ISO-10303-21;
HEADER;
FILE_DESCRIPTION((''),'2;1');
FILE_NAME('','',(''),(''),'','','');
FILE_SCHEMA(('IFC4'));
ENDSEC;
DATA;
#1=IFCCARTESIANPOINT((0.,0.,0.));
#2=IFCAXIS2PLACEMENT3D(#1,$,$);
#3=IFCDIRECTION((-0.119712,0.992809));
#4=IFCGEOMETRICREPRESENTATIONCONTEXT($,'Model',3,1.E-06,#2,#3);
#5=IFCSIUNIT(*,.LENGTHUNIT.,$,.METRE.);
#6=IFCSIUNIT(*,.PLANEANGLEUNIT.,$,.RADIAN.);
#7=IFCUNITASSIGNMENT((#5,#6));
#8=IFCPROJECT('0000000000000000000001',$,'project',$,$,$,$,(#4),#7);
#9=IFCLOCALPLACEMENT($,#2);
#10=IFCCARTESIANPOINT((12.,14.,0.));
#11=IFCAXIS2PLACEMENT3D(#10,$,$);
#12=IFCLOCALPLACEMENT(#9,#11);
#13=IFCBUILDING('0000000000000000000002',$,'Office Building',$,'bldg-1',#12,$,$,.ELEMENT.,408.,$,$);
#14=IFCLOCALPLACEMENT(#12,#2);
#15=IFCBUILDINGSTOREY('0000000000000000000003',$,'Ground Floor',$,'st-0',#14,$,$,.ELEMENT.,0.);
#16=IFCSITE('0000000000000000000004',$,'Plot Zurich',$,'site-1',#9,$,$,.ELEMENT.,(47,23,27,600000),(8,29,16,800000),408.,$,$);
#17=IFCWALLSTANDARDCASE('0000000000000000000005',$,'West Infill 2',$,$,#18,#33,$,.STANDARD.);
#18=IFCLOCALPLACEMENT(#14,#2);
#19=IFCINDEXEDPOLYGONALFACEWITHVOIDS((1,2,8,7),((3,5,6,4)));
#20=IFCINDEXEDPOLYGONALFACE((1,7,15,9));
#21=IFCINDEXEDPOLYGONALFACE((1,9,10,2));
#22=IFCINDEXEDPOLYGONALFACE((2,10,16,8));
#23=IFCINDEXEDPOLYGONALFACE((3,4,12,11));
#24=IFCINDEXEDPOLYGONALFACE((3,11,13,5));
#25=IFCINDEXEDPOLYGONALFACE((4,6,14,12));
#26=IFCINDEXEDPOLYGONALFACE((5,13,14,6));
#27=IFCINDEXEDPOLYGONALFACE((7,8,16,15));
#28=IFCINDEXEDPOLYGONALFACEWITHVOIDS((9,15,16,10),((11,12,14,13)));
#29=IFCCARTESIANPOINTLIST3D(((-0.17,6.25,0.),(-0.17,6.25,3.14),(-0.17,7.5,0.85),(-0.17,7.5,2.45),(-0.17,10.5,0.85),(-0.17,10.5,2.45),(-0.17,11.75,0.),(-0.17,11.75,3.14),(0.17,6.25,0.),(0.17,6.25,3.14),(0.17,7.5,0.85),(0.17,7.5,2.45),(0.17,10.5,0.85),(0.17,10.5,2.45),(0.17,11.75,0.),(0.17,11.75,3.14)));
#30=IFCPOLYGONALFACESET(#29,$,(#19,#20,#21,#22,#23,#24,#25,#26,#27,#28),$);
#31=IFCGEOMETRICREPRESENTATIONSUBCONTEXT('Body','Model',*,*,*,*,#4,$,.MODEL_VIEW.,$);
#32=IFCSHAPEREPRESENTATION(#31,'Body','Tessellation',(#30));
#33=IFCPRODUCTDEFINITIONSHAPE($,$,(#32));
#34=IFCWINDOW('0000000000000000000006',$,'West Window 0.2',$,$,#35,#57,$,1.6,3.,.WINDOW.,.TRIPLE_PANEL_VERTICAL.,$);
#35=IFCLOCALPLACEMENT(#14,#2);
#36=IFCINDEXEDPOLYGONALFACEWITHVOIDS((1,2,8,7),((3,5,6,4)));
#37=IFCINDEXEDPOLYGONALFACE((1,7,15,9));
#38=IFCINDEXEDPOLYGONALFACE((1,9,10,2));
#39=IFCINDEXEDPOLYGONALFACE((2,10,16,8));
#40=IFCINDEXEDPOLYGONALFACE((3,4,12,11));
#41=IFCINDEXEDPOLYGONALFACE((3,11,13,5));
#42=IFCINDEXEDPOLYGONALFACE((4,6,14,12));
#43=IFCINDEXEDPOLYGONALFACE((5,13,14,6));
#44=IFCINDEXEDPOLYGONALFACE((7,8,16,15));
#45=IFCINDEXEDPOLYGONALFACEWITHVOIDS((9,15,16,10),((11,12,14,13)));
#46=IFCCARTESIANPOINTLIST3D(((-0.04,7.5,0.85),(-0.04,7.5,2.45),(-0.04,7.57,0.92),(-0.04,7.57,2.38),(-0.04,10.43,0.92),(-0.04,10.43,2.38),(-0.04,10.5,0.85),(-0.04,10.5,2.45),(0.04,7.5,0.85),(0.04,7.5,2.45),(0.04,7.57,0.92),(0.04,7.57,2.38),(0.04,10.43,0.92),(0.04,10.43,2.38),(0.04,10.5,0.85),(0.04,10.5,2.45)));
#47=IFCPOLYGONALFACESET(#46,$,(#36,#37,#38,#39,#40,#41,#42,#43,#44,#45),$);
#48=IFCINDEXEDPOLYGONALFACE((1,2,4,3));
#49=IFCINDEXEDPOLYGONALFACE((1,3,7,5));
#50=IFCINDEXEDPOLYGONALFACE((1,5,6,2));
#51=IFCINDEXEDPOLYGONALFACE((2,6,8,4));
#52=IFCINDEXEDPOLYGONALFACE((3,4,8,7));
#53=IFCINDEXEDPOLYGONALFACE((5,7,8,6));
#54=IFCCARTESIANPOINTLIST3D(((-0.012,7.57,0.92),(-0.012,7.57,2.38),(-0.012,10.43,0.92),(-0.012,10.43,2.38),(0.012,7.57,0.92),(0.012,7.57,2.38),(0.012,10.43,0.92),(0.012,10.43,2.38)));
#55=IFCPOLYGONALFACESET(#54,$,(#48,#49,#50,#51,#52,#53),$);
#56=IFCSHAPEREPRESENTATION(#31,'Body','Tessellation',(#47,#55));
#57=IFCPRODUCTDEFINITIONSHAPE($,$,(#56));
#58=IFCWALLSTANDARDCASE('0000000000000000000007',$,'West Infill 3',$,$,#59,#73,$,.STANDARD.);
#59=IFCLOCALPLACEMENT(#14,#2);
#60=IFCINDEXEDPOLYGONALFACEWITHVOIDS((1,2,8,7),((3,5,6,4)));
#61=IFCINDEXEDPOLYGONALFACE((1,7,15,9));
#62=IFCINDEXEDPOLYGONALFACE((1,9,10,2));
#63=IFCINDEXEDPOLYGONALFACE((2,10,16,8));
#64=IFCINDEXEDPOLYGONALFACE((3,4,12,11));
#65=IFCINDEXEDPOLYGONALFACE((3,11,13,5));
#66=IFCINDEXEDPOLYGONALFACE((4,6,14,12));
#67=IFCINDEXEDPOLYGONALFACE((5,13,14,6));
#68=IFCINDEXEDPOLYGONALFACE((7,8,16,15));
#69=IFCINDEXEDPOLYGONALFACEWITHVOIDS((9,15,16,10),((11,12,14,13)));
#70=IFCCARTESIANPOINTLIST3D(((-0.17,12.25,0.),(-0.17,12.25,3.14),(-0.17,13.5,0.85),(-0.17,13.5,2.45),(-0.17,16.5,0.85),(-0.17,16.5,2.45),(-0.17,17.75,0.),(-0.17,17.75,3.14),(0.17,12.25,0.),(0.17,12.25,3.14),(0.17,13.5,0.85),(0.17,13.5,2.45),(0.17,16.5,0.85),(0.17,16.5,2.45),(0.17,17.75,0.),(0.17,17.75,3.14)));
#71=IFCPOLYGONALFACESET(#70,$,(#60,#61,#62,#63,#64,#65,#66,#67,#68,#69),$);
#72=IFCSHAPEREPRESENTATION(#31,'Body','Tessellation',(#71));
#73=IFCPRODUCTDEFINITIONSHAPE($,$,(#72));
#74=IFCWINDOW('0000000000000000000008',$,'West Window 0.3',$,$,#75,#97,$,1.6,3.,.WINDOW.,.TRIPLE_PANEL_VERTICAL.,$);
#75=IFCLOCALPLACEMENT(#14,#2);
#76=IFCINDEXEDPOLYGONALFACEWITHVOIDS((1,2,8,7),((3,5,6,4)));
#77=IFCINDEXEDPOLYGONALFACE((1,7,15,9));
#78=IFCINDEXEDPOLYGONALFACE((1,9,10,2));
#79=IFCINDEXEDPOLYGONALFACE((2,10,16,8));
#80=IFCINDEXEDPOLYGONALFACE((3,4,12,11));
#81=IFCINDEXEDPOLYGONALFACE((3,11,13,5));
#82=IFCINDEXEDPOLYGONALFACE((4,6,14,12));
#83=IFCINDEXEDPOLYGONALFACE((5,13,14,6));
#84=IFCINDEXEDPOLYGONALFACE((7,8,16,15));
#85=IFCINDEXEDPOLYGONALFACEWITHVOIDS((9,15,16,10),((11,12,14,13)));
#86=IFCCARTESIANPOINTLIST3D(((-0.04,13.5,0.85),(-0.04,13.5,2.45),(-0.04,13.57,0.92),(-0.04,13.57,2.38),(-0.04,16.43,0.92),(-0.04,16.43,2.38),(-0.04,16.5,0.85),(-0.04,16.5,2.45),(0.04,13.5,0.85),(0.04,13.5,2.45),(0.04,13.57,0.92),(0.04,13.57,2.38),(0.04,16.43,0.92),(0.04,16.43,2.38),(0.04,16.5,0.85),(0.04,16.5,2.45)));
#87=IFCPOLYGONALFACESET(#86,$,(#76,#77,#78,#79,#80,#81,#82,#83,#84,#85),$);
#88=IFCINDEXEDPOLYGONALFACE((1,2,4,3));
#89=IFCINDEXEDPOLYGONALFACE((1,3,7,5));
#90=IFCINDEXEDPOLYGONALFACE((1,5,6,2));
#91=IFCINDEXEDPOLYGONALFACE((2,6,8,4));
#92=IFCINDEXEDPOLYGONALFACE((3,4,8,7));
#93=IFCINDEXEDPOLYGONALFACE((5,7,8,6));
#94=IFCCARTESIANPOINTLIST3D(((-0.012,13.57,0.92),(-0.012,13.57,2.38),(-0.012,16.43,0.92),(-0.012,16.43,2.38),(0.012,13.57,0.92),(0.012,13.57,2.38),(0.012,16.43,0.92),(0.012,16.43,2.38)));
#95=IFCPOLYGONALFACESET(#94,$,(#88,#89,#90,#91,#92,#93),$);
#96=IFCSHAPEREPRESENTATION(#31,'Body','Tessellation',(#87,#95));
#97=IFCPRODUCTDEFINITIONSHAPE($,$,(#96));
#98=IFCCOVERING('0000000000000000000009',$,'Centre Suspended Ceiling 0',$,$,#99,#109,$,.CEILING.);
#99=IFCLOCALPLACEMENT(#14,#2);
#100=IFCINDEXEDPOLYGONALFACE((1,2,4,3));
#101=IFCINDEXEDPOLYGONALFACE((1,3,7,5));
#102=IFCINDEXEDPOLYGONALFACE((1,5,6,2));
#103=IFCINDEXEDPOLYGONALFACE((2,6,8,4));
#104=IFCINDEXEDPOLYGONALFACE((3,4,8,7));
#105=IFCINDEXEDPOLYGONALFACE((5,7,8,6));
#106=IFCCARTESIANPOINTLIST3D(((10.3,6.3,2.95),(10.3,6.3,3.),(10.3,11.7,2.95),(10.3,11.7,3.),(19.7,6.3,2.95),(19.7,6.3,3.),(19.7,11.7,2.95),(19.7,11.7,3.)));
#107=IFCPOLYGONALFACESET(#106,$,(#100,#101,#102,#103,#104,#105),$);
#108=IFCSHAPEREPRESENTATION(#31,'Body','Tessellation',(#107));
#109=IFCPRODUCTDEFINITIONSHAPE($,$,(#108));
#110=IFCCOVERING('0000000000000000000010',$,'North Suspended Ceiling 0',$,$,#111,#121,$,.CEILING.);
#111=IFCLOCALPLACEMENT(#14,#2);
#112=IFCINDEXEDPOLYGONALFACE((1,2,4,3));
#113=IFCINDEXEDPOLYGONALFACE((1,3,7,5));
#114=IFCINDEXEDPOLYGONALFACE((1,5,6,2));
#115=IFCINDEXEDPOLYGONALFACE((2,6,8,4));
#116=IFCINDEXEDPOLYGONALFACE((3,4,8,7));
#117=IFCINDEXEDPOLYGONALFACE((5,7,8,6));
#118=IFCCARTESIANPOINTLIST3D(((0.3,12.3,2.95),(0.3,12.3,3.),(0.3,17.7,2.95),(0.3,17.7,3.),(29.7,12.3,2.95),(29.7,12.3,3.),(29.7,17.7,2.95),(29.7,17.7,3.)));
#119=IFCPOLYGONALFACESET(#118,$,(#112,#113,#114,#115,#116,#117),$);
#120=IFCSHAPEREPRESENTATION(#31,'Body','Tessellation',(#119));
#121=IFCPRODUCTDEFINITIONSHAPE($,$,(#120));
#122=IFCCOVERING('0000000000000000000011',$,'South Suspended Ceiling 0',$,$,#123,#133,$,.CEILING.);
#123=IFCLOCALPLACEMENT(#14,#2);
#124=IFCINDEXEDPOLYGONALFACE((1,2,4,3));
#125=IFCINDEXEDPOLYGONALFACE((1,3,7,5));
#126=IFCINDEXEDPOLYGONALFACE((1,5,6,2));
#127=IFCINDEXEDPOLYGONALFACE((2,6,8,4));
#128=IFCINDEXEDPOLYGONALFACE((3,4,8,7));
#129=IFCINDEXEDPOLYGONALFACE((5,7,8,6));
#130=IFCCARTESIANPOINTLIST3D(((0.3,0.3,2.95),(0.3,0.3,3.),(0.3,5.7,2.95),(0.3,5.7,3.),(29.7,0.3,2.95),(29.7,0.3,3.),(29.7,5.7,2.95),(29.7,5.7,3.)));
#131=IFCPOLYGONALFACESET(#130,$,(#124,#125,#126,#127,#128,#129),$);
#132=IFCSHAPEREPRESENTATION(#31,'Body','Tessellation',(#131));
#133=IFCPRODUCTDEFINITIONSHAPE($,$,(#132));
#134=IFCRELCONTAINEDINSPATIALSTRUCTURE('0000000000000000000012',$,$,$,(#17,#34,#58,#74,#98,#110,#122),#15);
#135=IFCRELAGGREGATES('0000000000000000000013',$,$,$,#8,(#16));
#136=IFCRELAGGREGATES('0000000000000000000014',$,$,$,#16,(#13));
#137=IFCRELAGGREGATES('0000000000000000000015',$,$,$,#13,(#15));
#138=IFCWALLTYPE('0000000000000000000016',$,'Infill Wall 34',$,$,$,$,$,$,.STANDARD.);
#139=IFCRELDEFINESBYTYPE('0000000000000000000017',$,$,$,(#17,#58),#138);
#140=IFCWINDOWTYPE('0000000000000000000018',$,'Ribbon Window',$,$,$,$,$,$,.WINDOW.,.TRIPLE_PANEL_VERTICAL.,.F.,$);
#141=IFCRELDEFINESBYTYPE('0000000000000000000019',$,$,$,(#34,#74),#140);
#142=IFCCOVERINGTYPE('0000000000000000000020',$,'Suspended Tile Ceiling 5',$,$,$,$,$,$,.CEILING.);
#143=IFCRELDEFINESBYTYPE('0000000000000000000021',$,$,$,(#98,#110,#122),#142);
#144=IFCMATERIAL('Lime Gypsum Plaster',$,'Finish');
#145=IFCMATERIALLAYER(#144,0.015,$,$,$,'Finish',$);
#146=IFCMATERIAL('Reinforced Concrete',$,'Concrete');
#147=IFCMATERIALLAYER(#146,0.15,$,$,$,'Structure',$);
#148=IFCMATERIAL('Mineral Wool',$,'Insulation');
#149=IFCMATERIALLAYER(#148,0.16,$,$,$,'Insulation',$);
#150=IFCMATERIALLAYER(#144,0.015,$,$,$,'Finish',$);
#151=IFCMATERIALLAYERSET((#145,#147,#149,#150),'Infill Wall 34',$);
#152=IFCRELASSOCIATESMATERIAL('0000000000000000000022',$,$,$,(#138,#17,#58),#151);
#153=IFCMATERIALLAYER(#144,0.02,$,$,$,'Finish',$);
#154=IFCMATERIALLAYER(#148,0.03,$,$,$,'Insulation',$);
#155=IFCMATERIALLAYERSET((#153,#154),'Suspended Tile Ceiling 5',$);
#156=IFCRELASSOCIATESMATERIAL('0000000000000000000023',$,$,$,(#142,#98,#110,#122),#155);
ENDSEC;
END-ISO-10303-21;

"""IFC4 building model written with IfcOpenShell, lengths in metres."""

from ifc_helpers import new_model, si_unit, direction, frame, frame_2d, origin, origin_2d, place, context, subcontext, project, spatial, polyline, rectangle, outline, extrude, material, layer, layer_set, layer_usage, type_object, element, fill, save


model = new_model("IFC4")

# Units and contexts
model_context = context("Model", 3, precision=1e-06, world=origin(), true_north=direction((-0.119712, 0.992809)))
body_context = subcontext(model_context, "Body", "Model", "MODEL_VIEW")
ifc_project = project(units=[si_unit("LENGTHUNIT", "METRE"), si_unit("PLANEANGLEUNIT", "RADIAN")], contexts=[model_context])

# Site, building, storey
site_placement = place(None, origin())
site = spatial("IfcSite", under=ifc_project, at=site_placement, Name="Plot Zurich", ObjectType="site-1", CompositionType="ELEMENT", RefLatitude=(47, 23, 27, 600000), RefLongitude=(8, 29, 16, 800000), RefElevation=408.0)
building_placement = place(site_placement, frame((12.0, 14.0, 0.0)))
building = spatial("IfcBuilding", under=site, at=building_placement, Name="Office Building", ObjectType="bldg-1", CompositionType="ELEMENT", ElevationOfRefHeight=408.0)
storey_placement = place(building_placement, origin())
storey = spatial("IfcBuildingStorey", under=building, at=storey_placement, Name="Ground Floor", ObjectType="st-0", CompositionType="ELEMENT", Elevation=0.0)

# Shared definitions
ifc_material_1 = material(Name="Reinforced Concrete", Category="Concrete")

# Shared definitions
ifc_material_2 = material(Name="Mineral Wool", Category="Insulation")

# Walls, openings, windows
ifc_material_3 = material(Name="Lime Gypsum Plaster", Category="Finish")
ifc_layer_1 = layer(ifc_material_3, 0.015, Category="Finish")
ifc_layer_2 = layer(ifc_material_1, 0.15, Category="Structure")
ifc_layer_3 = layer(ifc_material_2, 0.16, Category="Insulation")
ifc_layer_4 = layer(ifc_material_3, 0.015, Category="Finish")
ifc_layer_set_1 = layer_set([ifc_layer_1, ifc_layer_2, ifc_layer_3, ifc_layer_4], Name="Infill Wall 34")
wall_type_1 = type_object("IfcWallType", Name="Infill Wall 34", PredefinedType="STANDARD", material=ifc_layer_set_1)
window_type = type_object("IfcWindowType", Name="Ribbon Window", ParameterTakesPrecedence=False, PartitioningType="TRIPLE_PANEL_VERTICAL", PredefinedType="WINDOW")
ifc_layer_usage_1 = layer_usage(ifc_layer_set_1, "AXIS2", "NEGATIVE", 0.17)
wall_1_placement = place(storey_placement, frame((0.0, 11.75, 0.0), z_axis=(0.0, 0.0, 1.0), x_axis=(0.0, -1.0, 0.0)))
wall_1 = element("IfcWallStandardCase", 1, at=wall_1_placement, inside=storey, type_object=wall_type_1, material=ifc_layer_usage_1, Name="West Infill 2", PredefinedType="STANDARD", context=body_context, shape_type="SweptSolid", body=[
    extrude(rectangle(XDim=5.5, YDim=0.34, at=frame_2d((2.75, 0.0))), origin(), (0.0, 0.0, 1.0), 3.14),
])
opening_1_placement = place(wall_1_placement, frame((2.75, 0.0, 0.85)))
opening_1 = element("IfcOpeningElement", 2, at=opening_1_placement, cuts=wall_1, PredefinedType="OPENING", context=body_context, shape_type="SweptSolid", body=[
    extrude(rectangle(XDim=3.0, YDim=0.34, at=origin_2d()), origin(), (0.0, 0.0, 1.0), 1.6),
])
window_1_placement = place(opening_1_placement, frame((0.0, 0.0, 0.0), z_axis=(0.0, -1.0, 0.0), x_axis=(1.0, 0.0, 0.0)))
window_1 = element("IfcWindow", 3, at=window_1_placement, inside=storey, type_object=window_type, Name="West Window 0.2", OverallHeight=1.6, OverallWidth=3.0, PartitioningType="TRIPLE_PANEL_VERTICAL", PredefinedType="WINDOW", context=body_context, shape_type="SweptSolid", body=[
    extrude(outline(polyline([(-1.5, 0.0), (1.5, 0.0), (1.5, 1.6), (-1.5, 1.6), (-1.5, 0.0)]), holes=[polyline([(-1.43, 0.07), (1.43, 0.07), (1.43, 1.53), (-1.43, 1.53), (-1.43, 0.07)])]), frame((0.0, 0.0, -0.04)), (0.0, 0.0, 1.0), 0.08),
    extrude(rectangle(XDim=2.86, YDim=1.46, at=frame_2d((0.0, 0.8))), frame((0.0, 0.0, -0.012)), (0.0, 0.0, 1.0), 0.024),
])
fill(opening_1, window_1)
ifc_layer_usage_2 = layer_usage(ifc_layer_set_1, "AXIS2", "NEGATIVE", 0.17)
wall_2_placement = place(storey_placement, frame((0.0, 17.75, 0.0), z_axis=(0.0, 0.0, 1.0), x_axis=(0.0, -1.0, 0.0)))
wall_2 = element("IfcWallStandardCase", 4, at=wall_2_placement, inside=storey, type_object=wall_type_1, material=ifc_layer_usage_2, Name="West Infill 3", PredefinedType="STANDARD", context=body_context, shape_type="SweptSolid", body=[
    extrude(rectangle(XDim=5.5, YDim=0.34, at=frame_2d((2.75, 0.0))), origin(), (0.0, 0.0, 1.0), 3.14),
])
opening_2_placement = place(wall_2_placement, frame((2.75, 0.0, 0.85)))
opening_2 = element("IfcOpeningElement", 5, at=opening_2_placement, cuts=wall_2, PredefinedType="OPENING", context=body_context, shape_type="SweptSolid", body=[
    extrude(rectangle(XDim=3.0, YDim=0.34, at=origin_2d()), origin(), (0.0, 0.0, 1.0), 1.6),
])
window_2_placement = place(opening_2_placement, frame((0.0, 0.0, 0.0), z_axis=(0.0, -1.0, 0.0), x_axis=(1.0, 0.0, 0.0)))
window_2 = element("IfcWindow", 6, at=window_2_placement, inside=storey, type_object=window_type, Name="West Window 0.3", OverallHeight=1.6, OverallWidth=3.0, PartitioningType="TRIPLE_PANEL_VERTICAL", PredefinedType="WINDOW", context=body_context, shape_type="SweptSolid", body=[
    extrude(outline(polyline([(-1.5, 0.0), (1.5, 0.0), (1.5, 1.6), (-1.5, 1.6), (-1.5, 0.0)]), holes=[polyline([(-1.43, 0.07), (1.43, 0.07), (1.43, 1.53), (-1.43, 1.53), (-1.43, 0.07)])]), frame((0.0, 0.0, -0.04)), (0.0, 0.0, 1.0), 0.08),
    extrude(rectangle(XDim=2.86, YDim=1.46, at=frame_2d((0.0, 0.8))), frame((0.0, 0.0, -0.012)), (0.0, 0.0, 1.0), 0.024),
])
fill(opening_2, window_2)

# Coverings
ifc_layer_5 = layer(ifc_material_3, 0.02, Category="Finish")
ifc_layer_6 = layer(ifc_material_2, 0.03, Category="Insulation")
ifc_layer_set_2 = layer_set([ifc_layer_5, ifc_layer_6], Name="Suspended Tile Ceiling 5")
ifc_layer_usage_3 = layer_usage(ifc_layer_set_2, "AXIS3", "NEGATIVE", 0.05)
covering_type = type_object("IfcCoveringType", Name="Suspended Tile Ceiling 5", PredefinedType="CEILING", material=ifc_layer_set_2)
covering_1_placement = place(storey_placement, frame((0.0, 0.0, 2.95)))
element("IfcCovering", 7, at=covering_1_placement, inside=storey, type_object=covering_type, material=ifc_layer_usage_3, Name="Centre Suspended Ceiling 0", PredefinedType="CEILING", context=body_context, shape_type="SweptSolid", body=[
    extrude(outline(polyline([(10.3, 6.3), (19.7, 6.3), (19.7, 11.7), (10.3, 11.7), (10.3, 6.3)])), origin(), (0.0, 0.0, 1.0), 0.05),
])
ifc_layer_usage_4 = layer_usage(ifc_layer_set_2, "AXIS3", "NEGATIVE", 0.05)
covering_2_placement = place(storey_placement, frame((0.0, 0.0, 2.95)))
element("IfcCovering", 8, at=covering_2_placement, inside=storey, type_object=covering_type, material=ifc_layer_usage_4, Name="North Suspended Ceiling 0", PredefinedType="CEILING", context=body_context, shape_type="SweptSolid", body=[
    extrude(outline(polyline([(0.3, 12.3), (29.7, 12.3), (29.7, 17.7), (0.3, 17.7), (0.3, 12.3)])), origin(), (0.0, 0.0, 1.0), 0.05),
])
ifc_layer_usage_5 = layer_usage(ifc_layer_set_2, "AXIS3", "NEGATIVE", 0.05)
covering_3_placement = place(storey_placement, frame((0.0, 0.0, 2.95)))
element("IfcCovering", 9, at=covering_3_placement, inside=storey, type_object=covering_type, material=ifc_layer_usage_5, Name="South Suspended Ceiling 0", PredefinedType="CEILING", context=body_context, shape_type="SweptSolid", body=[
    extrude(outline(polyline([(0.3, 0.3), (29.7, 0.3), (29.7, 5.7), (0.3, 5.7), (0.3, 0.3)])), origin(), (0.0, 0.0, 1.0), 0.05),
])

save(model, "model.ifc")
